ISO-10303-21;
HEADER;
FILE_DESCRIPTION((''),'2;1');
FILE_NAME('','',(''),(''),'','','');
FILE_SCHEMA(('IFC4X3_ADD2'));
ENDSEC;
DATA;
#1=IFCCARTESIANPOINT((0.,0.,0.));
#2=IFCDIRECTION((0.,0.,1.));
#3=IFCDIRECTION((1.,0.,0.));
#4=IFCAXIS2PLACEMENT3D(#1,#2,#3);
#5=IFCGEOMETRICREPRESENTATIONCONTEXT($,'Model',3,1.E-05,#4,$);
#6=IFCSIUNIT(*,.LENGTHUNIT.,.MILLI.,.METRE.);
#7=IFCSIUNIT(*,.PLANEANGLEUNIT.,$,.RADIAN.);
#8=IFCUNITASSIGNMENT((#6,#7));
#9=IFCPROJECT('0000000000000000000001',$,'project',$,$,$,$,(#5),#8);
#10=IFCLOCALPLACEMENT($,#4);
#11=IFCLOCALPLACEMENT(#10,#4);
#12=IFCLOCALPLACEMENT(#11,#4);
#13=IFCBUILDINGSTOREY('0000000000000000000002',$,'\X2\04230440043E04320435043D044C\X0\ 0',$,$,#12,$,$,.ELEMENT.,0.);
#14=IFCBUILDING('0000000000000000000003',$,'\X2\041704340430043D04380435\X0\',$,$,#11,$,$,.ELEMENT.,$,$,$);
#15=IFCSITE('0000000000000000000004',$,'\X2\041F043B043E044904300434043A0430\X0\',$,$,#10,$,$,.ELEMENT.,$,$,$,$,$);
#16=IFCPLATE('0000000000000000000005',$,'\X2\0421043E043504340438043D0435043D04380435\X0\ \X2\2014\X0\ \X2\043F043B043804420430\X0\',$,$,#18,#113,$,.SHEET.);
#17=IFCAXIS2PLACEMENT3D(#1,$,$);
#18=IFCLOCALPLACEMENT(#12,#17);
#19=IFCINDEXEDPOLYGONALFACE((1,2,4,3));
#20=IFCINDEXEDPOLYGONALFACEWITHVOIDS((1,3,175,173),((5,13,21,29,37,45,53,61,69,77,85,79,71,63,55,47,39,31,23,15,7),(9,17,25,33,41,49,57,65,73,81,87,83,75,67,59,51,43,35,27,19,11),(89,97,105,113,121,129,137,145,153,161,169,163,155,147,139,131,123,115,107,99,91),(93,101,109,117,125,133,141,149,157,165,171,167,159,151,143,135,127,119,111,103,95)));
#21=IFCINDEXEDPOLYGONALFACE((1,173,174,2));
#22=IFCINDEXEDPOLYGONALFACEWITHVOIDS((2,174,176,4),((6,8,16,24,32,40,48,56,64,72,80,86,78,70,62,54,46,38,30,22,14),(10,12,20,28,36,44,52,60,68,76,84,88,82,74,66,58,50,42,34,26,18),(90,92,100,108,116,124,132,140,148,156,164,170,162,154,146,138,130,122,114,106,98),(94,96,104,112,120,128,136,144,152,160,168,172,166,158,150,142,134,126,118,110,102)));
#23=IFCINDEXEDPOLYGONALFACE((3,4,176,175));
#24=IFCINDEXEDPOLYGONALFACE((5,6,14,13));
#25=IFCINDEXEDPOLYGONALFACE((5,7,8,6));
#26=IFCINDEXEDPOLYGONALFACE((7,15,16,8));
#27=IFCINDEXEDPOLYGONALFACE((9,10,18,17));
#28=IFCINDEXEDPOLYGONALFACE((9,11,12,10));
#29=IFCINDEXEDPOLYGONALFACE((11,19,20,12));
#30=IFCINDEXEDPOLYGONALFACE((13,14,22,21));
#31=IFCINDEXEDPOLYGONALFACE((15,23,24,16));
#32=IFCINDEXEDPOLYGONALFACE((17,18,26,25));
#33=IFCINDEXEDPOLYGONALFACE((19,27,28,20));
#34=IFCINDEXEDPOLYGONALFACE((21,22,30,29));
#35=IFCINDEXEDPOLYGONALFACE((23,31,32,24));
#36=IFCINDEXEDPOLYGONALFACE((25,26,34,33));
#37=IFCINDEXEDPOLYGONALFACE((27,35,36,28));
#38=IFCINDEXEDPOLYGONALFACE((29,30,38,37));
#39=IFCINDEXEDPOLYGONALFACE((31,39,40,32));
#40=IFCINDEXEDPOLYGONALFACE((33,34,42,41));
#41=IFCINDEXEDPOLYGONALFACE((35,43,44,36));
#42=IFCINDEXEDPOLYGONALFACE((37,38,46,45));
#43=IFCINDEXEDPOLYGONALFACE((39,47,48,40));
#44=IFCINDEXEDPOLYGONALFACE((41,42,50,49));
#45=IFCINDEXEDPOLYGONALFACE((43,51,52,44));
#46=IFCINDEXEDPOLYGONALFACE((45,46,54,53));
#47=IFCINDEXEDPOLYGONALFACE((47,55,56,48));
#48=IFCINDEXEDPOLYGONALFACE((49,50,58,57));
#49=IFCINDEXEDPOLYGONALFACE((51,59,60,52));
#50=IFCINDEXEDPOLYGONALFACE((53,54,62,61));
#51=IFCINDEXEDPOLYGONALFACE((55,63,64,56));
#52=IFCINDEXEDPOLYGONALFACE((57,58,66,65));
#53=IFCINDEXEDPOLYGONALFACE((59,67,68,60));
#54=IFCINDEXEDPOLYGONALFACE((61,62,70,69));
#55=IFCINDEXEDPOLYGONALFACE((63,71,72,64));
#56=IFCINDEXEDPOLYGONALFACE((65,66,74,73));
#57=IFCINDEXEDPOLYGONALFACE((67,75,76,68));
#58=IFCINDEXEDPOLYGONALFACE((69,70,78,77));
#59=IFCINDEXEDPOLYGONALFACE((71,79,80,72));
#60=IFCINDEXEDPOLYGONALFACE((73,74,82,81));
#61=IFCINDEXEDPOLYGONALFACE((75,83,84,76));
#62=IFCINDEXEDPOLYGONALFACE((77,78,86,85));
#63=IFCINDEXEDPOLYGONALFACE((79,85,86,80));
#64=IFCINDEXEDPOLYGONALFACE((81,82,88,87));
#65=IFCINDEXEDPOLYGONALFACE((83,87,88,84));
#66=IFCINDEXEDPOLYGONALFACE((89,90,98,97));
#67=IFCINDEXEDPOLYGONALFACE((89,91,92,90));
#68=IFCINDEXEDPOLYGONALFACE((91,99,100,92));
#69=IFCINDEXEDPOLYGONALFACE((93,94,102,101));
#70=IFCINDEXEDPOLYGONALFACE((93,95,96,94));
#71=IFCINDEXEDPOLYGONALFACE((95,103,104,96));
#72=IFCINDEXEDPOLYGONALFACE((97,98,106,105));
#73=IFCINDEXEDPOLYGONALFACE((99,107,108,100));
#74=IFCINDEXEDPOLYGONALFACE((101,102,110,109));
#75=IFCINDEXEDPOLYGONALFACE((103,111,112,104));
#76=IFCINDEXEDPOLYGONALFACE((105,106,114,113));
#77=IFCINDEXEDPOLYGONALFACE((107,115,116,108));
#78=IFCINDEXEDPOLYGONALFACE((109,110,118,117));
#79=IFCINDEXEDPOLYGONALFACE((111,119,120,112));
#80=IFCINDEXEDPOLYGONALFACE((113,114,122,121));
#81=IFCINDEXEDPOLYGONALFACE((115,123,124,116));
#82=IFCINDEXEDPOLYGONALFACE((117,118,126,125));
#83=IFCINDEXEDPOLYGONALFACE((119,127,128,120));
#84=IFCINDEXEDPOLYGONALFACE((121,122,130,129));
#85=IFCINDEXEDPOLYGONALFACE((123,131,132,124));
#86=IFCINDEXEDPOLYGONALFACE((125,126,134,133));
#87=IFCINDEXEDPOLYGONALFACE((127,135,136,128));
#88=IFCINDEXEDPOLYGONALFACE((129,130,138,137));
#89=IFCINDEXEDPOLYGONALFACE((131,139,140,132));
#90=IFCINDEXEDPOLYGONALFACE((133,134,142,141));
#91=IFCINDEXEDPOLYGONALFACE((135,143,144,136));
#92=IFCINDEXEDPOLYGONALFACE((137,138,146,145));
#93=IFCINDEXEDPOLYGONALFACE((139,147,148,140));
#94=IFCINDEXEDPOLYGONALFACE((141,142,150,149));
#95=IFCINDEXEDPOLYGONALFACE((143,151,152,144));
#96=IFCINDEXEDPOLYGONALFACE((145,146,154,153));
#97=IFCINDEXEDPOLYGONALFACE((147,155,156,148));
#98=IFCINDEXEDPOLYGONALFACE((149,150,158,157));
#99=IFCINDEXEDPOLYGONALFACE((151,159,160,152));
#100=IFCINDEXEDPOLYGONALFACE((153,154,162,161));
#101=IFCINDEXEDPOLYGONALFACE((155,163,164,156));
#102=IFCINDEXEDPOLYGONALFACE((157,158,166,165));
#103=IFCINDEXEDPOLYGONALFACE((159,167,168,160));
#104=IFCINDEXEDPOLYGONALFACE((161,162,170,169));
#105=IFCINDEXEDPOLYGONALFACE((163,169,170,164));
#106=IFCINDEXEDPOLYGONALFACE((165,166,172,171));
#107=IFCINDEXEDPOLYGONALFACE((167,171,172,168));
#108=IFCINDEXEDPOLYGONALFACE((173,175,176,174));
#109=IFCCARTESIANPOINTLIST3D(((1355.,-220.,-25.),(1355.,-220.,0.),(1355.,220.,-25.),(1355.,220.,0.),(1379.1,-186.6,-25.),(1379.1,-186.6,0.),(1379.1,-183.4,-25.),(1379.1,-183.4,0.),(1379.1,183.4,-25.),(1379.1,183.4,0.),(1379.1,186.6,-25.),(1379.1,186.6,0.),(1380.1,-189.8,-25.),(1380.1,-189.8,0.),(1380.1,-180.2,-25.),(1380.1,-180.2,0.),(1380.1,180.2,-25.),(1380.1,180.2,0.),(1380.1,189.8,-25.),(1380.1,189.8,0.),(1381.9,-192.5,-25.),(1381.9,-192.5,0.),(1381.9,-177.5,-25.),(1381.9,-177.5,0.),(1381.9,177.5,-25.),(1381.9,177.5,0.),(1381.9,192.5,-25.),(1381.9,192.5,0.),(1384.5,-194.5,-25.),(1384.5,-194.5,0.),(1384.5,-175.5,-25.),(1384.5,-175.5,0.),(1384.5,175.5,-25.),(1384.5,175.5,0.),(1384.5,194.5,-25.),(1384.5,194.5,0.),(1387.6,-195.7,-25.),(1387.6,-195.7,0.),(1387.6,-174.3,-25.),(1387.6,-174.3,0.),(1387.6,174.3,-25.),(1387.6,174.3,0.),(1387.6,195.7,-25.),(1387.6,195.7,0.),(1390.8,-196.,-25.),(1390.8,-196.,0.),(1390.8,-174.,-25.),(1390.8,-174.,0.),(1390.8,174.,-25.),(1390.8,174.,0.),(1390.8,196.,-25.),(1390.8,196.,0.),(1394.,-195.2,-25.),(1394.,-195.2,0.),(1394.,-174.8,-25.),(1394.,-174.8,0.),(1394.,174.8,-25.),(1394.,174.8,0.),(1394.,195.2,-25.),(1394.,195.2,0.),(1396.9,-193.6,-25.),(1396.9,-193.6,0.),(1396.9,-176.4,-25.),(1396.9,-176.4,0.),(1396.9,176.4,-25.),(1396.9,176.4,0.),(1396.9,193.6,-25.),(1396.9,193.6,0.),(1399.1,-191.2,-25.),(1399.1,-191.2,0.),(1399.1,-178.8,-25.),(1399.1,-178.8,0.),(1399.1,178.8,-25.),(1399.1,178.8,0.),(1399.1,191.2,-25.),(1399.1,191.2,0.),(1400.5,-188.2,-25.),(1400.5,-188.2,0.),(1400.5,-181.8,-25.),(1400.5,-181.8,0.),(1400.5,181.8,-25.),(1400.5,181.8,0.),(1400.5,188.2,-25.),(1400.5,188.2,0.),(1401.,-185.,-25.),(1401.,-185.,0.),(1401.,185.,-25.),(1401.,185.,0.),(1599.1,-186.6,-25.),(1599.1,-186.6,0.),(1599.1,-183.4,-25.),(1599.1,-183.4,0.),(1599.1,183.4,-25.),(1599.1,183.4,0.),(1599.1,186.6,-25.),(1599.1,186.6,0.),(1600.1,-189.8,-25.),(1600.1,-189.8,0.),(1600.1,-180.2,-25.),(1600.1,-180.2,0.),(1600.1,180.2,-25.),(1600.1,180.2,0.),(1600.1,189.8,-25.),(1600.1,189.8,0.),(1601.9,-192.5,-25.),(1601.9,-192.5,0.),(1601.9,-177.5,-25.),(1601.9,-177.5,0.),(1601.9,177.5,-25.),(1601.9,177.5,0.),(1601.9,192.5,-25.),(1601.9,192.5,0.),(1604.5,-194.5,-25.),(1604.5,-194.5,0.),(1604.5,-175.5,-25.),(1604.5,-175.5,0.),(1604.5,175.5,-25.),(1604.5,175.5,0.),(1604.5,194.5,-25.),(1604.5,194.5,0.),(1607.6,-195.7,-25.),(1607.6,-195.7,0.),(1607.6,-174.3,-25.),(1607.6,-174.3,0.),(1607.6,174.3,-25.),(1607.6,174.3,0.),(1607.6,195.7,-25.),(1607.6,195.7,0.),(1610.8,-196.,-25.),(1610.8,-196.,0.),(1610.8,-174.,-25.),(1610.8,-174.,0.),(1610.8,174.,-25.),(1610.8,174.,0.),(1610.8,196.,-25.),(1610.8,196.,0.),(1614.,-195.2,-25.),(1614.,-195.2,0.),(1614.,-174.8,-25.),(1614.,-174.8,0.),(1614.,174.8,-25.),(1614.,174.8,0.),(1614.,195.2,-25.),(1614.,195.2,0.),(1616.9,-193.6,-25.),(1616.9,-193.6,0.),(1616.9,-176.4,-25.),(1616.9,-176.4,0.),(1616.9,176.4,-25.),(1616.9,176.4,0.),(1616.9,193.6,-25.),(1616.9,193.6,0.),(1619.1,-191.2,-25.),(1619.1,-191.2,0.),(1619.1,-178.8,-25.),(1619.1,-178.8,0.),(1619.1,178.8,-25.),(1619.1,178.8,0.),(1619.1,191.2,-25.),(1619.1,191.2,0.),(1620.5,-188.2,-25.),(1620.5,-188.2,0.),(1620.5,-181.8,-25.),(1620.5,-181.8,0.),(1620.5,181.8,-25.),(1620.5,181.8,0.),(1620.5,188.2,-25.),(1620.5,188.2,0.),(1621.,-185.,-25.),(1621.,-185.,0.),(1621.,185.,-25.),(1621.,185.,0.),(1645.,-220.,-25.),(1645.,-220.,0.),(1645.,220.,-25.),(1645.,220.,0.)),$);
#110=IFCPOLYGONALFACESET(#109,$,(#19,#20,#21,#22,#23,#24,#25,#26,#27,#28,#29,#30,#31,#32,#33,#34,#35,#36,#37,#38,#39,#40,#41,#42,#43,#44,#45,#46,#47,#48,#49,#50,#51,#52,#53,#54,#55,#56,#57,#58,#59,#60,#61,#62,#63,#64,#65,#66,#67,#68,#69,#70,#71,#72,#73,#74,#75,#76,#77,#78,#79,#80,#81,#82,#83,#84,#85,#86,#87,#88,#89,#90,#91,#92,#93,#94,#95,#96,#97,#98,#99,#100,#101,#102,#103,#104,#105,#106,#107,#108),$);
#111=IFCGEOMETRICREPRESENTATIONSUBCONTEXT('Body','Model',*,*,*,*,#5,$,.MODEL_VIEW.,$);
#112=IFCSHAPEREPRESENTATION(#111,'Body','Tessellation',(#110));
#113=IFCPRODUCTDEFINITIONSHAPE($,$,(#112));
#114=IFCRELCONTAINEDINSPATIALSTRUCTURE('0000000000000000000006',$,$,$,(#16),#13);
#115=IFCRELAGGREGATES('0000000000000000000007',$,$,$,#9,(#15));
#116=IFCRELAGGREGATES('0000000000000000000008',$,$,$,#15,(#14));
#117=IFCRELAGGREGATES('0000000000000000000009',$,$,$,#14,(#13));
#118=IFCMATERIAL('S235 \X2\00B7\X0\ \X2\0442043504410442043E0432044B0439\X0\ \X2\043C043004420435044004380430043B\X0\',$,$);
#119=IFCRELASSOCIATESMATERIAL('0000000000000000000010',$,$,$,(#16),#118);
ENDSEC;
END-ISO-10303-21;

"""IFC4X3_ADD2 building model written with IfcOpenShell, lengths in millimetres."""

from ifc_helpers import new_model, si_unit, frame, origin_with_axes, place, context, subcontext, project, spatial, polyline, circle, outline, extrude, material, element, save


model = new_model("IFC4X3_ADD2")

# Units and contexts
model_context = context("Model", 3, precision=1e-05, world=origin_with_axes())
body_context = subcontext(model_context, "Body", "Model", "MODEL_VIEW")
ifc_project = project(units=[si_unit("LENGTHUNIT", "METRE", prefix="MILLI"), si_unit("PLANEANGLEUNIT", "RADIAN")], contexts=[model_context])

# Site, building, storey
site_placement = place(None, origin_with_axes())
site = spatial("IfcSite", under=ifc_project, at=site_placement, Name="Площадка", CompositionType="ELEMENT")
building_placement = place(site_placement, origin_with_axes())
building = spatial("IfcBuilding", under=site, at=building_placement, Name="Здание", CompositionType="ELEMENT")
storey_placement = place(building_placement, origin_with_axes())
storey = spatial("IfcBuildingStorey", under=building, at=storey_placement, Name="Уровень 0", CompositionType="ELEMENT", Elevation=0.0)

# Shared definitions
ifc_material = material(Name="S235 · тестовый материал")

# Plate, openings
plate_1_placement = place(storey_placement, frame((1355.0, -220.0, -25.0), z_axis=(0.0, 0.0, 1.0), x_axis=(1.0, 0.0, 0.0)))
plate_1 = element("IfcPlate", 1, at=plate_1_placement, inside=storey, material=ifc_material, Name="Соединение — плита", PredefinedType="SHEET", context=body_context, shape_type="SweptSolid", body=[
    extrude(outline(polyline([(0.0, 0.0), (290.0, 0.0), (290.0, 440.0), (0.0, 440.0), (0.0, 0.0)])), origin_with_axes(), (0.0, 0.0, 1.0), 25.0),
])
opening_1_placement = place(plate_1_placement, frame((35.0, 35.0, -1.0), z_axis=(0.0, 0.0, 1.0), x_axis=(1.0, 0.0, 0.0)))
element("IfcOpeningElement", 2, at=opening_1_placement, cuts=plate_1, PredefinedType="OPENING", context=body_context, shape_type="SweptSolid", body=[
    extrude(circle(Radius=11.0), origin_with_axes(), (0.0, 0.0, 1.0), 27.0),
])
opening_2_placement = place(plate_1_placement, frame((255.0, 35.0, -1.0), z_axis=(0.0, 0.0, 1.0), x_axis=(1.0, 0.0, 0.0)))
element("IfcOpeningElement", 3, at=opening_2_placement, cuts=plate_1, PredefinedType="OPENING", context=body_context, shape_type="SweptSolid", body=[
    extrude(circle(Radius=11.0), origin_with_axes(), (0.0, 0.0, 1.0), 27.0),
])
opening_3_placement = place(plate_1_placement, frame((35.0, 405.0, -1.0), z_axis=(0.0, 0.0, 1.0), x_axis=(1.0, 0.0, 0.0)))
element("IfcOpeningElement", 4, at=opening_3_placement, cuts=plate_1, PredefinedType="OPENING", context=body_context, shape_type="SweptSolid", body=[
    extrude(circle(Radius=11.0), origin_with_axes(), (0.0, 0.0, 1.0), 27.0),
])
opening_4_placement = place(plate_1_placement, frame((255.0, 405.0, -1.0), z_axis=(0.0, 0.0, 1.0), x_axis=(1.0, 0.0, 0.0)))
element("IfcOpeningElement", 5, at=opening_4_placement, cuts=plate_1, PredefinedType="OPENING", context=body_context, shape_type="SweptSolid", body=[
    extrude(circle(Radius=11.0), origin_with_axes(), (0.0, 0.0, 1.0), 27.0),
])

save(model, "model.ifc")
